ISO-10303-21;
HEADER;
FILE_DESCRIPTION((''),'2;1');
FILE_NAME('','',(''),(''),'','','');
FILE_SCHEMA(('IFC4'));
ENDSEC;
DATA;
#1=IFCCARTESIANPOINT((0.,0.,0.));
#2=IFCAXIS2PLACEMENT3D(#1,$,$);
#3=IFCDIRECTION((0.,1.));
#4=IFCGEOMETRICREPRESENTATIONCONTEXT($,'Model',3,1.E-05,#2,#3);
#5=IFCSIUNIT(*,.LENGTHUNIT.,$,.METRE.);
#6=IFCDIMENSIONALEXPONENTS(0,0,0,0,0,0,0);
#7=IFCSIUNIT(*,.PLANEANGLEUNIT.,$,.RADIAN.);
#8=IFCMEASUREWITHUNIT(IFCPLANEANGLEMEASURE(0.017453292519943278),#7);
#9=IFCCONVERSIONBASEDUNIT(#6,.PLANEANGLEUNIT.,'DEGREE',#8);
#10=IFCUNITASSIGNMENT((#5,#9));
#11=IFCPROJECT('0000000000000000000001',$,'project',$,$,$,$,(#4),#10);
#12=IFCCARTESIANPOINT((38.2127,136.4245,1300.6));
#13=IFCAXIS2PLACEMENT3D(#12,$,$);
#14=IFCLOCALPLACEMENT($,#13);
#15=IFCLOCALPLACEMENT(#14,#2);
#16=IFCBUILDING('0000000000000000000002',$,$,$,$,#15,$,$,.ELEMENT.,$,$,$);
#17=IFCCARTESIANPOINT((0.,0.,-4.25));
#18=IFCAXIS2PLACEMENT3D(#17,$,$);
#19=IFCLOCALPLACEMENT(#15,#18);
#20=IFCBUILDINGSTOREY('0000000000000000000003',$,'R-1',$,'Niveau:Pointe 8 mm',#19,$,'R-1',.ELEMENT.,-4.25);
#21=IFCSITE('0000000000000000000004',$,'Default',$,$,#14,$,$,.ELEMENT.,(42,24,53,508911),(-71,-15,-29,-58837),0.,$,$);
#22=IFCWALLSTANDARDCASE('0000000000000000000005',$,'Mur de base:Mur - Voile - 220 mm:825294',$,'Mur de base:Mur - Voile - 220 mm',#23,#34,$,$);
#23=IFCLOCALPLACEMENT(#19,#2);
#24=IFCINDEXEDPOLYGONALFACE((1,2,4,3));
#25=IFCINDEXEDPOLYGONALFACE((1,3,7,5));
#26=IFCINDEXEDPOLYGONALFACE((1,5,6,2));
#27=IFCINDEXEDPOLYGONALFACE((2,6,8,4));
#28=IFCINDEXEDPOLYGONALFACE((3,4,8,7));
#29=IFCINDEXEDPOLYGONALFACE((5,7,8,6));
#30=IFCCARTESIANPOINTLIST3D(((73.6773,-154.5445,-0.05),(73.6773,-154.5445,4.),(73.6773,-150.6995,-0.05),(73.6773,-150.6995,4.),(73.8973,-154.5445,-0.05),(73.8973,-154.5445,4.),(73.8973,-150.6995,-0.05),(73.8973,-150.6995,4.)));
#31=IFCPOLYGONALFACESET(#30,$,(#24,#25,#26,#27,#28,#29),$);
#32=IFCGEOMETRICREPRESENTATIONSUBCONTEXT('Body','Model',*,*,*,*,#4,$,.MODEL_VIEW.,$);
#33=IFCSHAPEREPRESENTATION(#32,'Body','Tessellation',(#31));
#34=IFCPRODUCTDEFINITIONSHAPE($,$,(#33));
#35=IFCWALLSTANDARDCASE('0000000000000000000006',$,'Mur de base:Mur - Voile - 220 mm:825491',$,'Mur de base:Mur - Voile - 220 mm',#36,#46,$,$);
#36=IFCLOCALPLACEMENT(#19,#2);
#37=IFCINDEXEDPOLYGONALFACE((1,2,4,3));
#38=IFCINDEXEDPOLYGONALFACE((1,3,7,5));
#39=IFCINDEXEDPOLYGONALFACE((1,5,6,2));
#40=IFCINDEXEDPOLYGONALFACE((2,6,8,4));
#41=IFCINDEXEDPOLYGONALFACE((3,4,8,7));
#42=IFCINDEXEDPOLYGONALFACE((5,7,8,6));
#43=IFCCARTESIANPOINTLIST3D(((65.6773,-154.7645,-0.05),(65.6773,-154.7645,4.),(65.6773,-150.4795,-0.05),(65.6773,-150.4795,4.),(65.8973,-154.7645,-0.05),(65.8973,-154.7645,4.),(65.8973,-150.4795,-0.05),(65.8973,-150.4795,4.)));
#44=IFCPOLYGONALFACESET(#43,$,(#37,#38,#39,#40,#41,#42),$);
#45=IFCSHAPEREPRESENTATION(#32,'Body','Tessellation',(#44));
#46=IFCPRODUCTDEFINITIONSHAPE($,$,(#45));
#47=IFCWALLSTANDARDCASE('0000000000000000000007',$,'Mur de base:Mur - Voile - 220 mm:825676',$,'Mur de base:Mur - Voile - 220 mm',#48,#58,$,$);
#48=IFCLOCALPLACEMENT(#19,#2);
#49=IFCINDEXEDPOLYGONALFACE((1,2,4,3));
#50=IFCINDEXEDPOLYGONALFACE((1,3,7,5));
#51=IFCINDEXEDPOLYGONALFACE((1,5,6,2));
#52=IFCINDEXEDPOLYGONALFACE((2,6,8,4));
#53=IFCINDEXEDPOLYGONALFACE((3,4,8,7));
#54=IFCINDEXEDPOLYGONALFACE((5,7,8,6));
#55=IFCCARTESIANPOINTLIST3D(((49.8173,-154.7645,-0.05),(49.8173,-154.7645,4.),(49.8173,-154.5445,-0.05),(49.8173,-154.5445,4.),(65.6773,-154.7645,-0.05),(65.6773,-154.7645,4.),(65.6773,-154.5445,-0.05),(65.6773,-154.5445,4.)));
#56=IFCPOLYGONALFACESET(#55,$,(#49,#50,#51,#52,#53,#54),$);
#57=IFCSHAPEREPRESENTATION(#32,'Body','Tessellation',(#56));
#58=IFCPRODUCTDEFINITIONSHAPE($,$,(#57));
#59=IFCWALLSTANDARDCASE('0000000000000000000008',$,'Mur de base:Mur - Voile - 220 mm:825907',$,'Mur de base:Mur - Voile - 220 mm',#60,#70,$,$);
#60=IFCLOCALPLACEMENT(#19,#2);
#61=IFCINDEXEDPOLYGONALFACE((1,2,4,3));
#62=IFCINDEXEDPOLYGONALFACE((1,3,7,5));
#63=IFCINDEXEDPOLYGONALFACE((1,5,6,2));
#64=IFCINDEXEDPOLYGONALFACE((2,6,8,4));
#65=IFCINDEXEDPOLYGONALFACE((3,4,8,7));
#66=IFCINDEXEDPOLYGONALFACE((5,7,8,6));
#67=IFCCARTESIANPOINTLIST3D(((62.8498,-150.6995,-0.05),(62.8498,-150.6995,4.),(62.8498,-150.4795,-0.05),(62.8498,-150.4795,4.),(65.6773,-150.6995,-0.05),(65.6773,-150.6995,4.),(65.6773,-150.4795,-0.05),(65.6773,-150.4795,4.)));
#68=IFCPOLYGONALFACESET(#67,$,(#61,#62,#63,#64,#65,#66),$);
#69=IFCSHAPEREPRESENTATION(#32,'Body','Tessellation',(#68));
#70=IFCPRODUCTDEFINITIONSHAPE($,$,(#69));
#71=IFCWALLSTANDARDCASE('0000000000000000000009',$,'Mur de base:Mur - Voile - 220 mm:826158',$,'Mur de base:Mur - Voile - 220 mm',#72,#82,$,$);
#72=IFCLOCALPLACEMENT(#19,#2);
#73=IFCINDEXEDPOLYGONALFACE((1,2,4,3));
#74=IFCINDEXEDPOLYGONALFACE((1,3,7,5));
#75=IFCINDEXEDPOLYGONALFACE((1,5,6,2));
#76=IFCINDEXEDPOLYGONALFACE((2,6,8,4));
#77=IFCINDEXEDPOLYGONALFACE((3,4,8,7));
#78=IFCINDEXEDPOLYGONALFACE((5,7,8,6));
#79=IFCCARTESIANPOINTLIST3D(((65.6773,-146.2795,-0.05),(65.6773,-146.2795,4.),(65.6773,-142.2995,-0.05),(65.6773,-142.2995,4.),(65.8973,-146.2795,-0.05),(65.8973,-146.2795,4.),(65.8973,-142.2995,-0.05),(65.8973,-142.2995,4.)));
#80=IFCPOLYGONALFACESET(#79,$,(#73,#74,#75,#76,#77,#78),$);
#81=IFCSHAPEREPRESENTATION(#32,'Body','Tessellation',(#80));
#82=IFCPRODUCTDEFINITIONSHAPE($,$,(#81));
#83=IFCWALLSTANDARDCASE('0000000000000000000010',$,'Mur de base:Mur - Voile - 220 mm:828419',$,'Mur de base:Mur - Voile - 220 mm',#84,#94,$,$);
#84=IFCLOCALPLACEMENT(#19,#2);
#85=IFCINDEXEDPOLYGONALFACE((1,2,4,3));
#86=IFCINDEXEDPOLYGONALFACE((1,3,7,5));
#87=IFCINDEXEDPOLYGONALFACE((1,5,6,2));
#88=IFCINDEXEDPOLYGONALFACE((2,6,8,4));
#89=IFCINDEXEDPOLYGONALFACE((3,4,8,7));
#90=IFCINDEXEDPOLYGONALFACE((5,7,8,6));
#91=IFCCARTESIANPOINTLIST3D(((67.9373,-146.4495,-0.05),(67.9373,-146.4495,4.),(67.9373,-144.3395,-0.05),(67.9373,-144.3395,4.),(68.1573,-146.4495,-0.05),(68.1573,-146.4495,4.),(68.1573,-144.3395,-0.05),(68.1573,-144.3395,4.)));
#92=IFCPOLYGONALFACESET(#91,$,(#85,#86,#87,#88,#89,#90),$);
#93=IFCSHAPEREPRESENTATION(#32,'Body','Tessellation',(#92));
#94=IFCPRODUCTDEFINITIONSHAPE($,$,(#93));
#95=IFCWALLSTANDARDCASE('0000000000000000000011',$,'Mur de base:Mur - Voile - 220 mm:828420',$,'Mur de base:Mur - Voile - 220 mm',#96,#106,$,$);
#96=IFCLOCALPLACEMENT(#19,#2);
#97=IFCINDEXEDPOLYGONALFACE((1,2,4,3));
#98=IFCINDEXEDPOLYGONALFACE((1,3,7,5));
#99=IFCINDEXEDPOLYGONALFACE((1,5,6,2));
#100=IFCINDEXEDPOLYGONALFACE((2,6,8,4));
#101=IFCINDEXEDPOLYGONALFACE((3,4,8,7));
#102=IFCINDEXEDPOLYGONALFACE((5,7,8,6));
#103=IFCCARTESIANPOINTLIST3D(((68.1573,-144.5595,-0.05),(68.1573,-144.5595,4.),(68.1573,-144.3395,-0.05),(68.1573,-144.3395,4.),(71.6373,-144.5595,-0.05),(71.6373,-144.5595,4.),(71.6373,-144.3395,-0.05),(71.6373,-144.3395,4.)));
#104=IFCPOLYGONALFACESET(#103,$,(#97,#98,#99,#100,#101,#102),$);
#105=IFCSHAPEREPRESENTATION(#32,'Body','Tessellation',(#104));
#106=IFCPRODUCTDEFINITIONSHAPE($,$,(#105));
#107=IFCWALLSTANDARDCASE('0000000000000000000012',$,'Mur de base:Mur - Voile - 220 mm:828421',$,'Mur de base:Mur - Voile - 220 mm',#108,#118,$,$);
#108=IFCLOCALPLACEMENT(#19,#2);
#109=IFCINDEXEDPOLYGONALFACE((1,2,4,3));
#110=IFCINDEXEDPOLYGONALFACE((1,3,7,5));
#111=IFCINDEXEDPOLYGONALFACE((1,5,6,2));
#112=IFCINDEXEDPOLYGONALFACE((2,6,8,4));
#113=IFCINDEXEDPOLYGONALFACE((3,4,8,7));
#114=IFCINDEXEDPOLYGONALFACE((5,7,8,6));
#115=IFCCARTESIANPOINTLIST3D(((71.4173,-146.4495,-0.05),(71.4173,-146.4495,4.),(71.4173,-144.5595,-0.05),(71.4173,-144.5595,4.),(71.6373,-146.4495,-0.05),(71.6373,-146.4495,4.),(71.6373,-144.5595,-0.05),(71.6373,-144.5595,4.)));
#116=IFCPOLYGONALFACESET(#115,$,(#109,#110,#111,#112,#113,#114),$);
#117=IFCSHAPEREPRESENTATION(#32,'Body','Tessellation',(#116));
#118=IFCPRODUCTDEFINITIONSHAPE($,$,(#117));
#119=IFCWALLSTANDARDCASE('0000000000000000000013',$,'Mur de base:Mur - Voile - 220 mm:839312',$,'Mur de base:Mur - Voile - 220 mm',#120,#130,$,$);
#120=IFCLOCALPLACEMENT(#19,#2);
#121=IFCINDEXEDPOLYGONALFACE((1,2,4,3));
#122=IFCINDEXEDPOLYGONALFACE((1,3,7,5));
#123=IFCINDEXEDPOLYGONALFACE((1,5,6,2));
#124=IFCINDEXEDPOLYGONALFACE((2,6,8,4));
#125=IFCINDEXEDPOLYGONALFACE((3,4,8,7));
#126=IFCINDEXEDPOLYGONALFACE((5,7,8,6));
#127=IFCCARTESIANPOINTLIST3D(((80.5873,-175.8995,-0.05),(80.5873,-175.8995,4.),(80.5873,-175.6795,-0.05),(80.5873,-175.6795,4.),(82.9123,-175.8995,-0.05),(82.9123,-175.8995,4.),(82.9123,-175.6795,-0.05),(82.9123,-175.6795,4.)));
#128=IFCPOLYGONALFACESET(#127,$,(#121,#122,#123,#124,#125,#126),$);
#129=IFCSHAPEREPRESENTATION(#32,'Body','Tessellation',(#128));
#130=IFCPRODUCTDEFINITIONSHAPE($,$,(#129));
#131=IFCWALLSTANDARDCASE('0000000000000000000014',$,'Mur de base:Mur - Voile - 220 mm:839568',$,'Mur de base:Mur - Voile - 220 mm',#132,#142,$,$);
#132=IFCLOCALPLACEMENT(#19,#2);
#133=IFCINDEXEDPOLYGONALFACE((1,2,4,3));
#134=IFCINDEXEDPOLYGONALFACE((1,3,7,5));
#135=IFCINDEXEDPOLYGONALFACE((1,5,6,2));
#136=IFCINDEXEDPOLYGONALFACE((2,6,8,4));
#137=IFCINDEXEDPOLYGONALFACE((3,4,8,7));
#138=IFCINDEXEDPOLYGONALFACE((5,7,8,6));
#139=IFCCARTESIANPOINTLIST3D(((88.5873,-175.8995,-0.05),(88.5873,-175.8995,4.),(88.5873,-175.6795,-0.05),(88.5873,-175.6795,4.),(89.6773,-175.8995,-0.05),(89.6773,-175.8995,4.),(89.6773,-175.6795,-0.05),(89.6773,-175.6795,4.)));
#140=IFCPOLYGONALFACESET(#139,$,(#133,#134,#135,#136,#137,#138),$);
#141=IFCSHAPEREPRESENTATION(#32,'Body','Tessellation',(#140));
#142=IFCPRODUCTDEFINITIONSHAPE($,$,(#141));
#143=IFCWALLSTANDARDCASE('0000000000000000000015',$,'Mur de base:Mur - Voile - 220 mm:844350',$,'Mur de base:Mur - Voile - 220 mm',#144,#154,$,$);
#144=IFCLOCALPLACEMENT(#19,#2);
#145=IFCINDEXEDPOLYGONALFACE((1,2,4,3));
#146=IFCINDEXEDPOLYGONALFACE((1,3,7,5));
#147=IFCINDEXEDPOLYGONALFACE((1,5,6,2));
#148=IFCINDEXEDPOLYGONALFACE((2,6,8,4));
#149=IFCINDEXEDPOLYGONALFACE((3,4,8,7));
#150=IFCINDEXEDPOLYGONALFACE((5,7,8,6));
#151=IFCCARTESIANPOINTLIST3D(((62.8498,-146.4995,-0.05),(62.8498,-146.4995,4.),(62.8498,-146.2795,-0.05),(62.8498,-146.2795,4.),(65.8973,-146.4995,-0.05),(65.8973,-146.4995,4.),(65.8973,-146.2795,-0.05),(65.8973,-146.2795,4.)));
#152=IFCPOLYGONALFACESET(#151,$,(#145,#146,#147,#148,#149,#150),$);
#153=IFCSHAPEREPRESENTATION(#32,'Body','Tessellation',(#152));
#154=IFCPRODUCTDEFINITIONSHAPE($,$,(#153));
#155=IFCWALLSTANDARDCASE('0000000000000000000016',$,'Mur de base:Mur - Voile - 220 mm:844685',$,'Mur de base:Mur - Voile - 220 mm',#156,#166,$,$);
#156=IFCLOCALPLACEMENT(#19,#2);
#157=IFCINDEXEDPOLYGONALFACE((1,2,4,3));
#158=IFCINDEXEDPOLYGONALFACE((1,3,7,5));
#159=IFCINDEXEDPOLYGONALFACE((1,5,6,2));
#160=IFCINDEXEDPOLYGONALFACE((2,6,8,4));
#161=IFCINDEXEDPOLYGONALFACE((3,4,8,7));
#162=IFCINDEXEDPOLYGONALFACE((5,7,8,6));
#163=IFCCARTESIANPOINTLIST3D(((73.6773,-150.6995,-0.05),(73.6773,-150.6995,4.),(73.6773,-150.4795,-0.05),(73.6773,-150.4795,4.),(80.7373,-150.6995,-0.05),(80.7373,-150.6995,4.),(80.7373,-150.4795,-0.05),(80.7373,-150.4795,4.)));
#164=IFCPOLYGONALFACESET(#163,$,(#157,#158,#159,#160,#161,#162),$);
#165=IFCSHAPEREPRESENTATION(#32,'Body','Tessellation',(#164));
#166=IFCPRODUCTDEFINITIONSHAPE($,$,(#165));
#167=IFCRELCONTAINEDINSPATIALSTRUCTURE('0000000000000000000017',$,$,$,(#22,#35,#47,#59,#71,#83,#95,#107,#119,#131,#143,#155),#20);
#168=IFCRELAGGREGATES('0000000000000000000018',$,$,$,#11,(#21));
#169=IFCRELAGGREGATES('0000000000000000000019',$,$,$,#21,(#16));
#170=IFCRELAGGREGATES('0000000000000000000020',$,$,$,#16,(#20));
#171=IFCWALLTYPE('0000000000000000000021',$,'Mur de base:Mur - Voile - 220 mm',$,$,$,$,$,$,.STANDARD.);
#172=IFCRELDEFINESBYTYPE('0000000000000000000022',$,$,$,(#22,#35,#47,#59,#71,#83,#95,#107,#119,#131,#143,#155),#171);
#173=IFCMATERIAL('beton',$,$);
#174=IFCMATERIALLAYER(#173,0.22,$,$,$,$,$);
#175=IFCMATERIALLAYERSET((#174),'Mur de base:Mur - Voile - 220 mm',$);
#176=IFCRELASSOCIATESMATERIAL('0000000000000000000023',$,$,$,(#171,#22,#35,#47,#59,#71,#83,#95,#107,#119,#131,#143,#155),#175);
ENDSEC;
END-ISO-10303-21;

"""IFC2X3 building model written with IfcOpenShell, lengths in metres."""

from ifc_helpers import new_model, entity, si_unit, converted_unit, direction, frame, frame_2d, origin, place, context, subcontext, project, spatial, polyline, rectangle, extrude, clip, bounded_halfspace, material, layer, layer_set, layer_usage, type_object, element, save


model = new_model("IFC2X3")

# Units and contexts
model_context = context("Model", 3, precision=1e-05, world=origin(), true_north=direction((0.0, 1.0)))
body_context = subcontext(model_context, "Body", "Model", "MODEL_VIEW")
ifc_project = project(units=[si_unit("LENGTHUNIT", "METRE"), converted_unit("PLANEANGLEUNIT", "DEGREE", entity("IfcPlaneAngleMeasure", 0.017453292519943278), si_unit("PLANEANGLEUNIT", "RADIAN"), dimensions=[0, 0, 0, 0, 0, 0, 0])], contexts=[model_context])

# Site, building, storey
site_placement = place(None, frame((38.2127, 136.4245, 1300.6)))
site = spatial("IfcSite", under=ifc_project, at=site_placement, Name="Default", CompositionType="ELEMENT", RefLatitude=(42, 24, 53, 508911), RefLongitude=(-71, -15, -29, -58837), RefElevation=0.0)
building_placement = place(site_placement, origin())
building = spatial("IfcBuilding", under=site, at=building_placement, CompositionType="ELEMENT")
storey_placement = place(building_placement, frame((0.0, 0.0, -4.25)))
storey = spatial("IfcBuildingStorey", under=building, at=storey_placement, Name="R-1", ObjectType="Niveau:Pointe 8 mm", LongName="R-1", CompositionType="ELEMENT", Elevation=-4.25)

# Walls
ifc_material_1 = material(Name="beton")
ifc_layer = layer(ifc_material_1, 0.22)
ifc_layer_set = layer_set([ifc_layer], Name="Mur de base:Mur - Voile - 220 mm")
wall_type = type_object("IfcWallType", Name="Mur de base:Mur - Voile - 220 mm", PredefinedType="STANDARD", material=ifc_layer_set)
ifc_layer_usage_1 = layer_usage(ifc_layer_set, "AXIS2", "NEGATIVE", 0.11)
wall_1_placement = place(storey_placement, frame((73.7873, -154.5445, -0.05), z_axis=(0.0, 0.0, 1.0), x_axis=(0.0, 1.0, 0.0)))
element("IfcWallStandardCase", 1, at=wall_1_placement, inside=storey, type_object=wall_type, material=ifc_layer_usage_1, Name="Mur de base:Mur - Voile - 220 mm:825294", ObjectType="Mur de base:Mur - Voile - 220 mm", context=body_context, shape_type="Clipping", body=[
    clip(extrude(rectangle(XDim=3.845, YDim=0.22, at=frame_2d((1.9225, 0.0), x_axis=(-1.0, 0.0))), origin(), (0.0, 0.0, 1.0), 4.05), bounded_halfspace(frame((0.0, -0.11, 4.05), z_axis=(0.0, 0.0, -1.0), x_axis=(-1.0, 0.0, 0.0)), True, frame((0.0, -0.11, 4.05)), polyline([(0.0, 0.0), (3.845, 0.0), (3.845, 0.22), (0.0, 0.22), (0.0, 0.0)]))),
])
ifc_layer_usage_2 = layer_usage(ifc_layer_set, "AXIS2", "NEGATIVE", 0.11)
wall_2_placement = place(storey_placement, frame((65.7873, -154.7645, -0.05), z_axis=(0.0, 0.0, 1.0), x_axis=(0.0, 1.0, 0.0)))
element("IfcWallStandardCase", 2, at=wall_2_placement, inside=storey, type_object=wall_type, material=ifc_layer_usage_2, Name="Mur de base:Mur - Voile - 220 mm:825491", ObjectType="Mur de base:Mur - Voile - 220 mm", context=body_context, shape_type="Clipping", body=[
    clip(extrude(rectangle(XDim=4.285, YDim=0.22, at=frame_2d((2.1425, 0.0), x_axis=(-1.0, 0.0))), origin(), (0.0, 0.0, 1.0), 4.05), bounded_halfspace(frame((0.0, -0.11, 4.05), z_axis=(0.0, 0.0, -1.0), x_axis=(-1.0, 0.0, 0.0)), True, frame((0.0, -0.11, 4.05)), polyline([(0.0, 0.0), (0.22, 0.0), (4.285, 0.0), (4.285, 0.22), (4.065, 0.22), (0.22, 0.22), (0.0, 0.22), (0.0, 0.0)]))),
])
ifc_layer_usage_3 = layer_usage(ifc_layer_set, "AXIS2", "NEGATIVE", 0.11)
wall_3_placement = place(storey_placement, frame((65.6773, -154.6545, -0.05), z_axis=(0.0, 0.0, 1.0), x_axis=(-1.0, 0.0, 0.0)))
element("IfcWallStandardCase", 3, at=wall_3_placement, inside=storey, type_object=wall_type, material=ifc_layer_usage_3, Name="Mur de base:Mur - Voile - 220 mm:825676", ObjectType="Mur de base:Mur - Voile - 220 mm", context=body_context, shape_type="Clipping", body=[
    clip(extrude(rectangle(XDim=15.86, YDim=0.22, at=frame_2d((7.93, 0.0), x_axis=(-1.0, 0.0))), origin(), (0.0, 0.0, 1.0), 4.05), bounded_halfspace(frame((0.0, -0.11, 4.05), z_axis=(0.0, 0.0, -1.0), x_axis=(0.0, 1.0, 0.0)), True, frame((0.0, -0.11, 4.05)), polyline([(0.0, 0.0), (15.44, 0.0), (15.79, 0.0), (15.86, 0.0), (15.86, 0.22), (15.79, 0.22), (15.44, 0.22), (0.0, 0.22), (0.0, 0.0)]))),
])
ifc_layer_usage_4 = layer_usage(ifc_layer_set, "AXIS2", "NEGATIVE", 0.11)
wall_4_placement = place(storey_placement, frame((65.6773, -150.5895, -0.05), z_axis=(0.0, 0.0, 1.0), x_axis=(-1.0, 0.0, 0.0)))
element("IfcWallStandardCase", 4, at=wall_4_placement, inside=storey, type_object=wall_type, material=ifc_layer_usage_4, Name="Mur de base:Mur - Voile - 220 mm:825907", ObjectType="Mur de base:Mur - Voile - 220 mm", context=body_context, shape_type="Clipping", body=[
    clip(extrude(rectangle(XDim=2.8275, YDim=0.22, at=frame_2d((1.4138, 0.0), x_axis=(-1.0, 0.0))), origin(), (0.0, 0.0, 1.0), 4.05), bounded_halfspace(frame((0.0, -0.11, 4.05), z_axis=(0.0, 0.0, -1.0), x_axis=(0.0, 1.0, 0.0)), True, frame((0.0, -0.11, 4.05)), polyline([(0.0, 0.0), (2.8275, 0.0), (2.8275, 0.22), (0.0, 0.22), (0.0, 0.0)]))),
])
ifc_layer_usage_5 = layer_usage(ifc_layer_set, "AXIS2", "NEGATIVE", 0.11)
wall_5_placement = place(storey_placement, frame((65.7873, -146.2795, -0.05), z_axis=(0.0, 0.0, 1.0), x_axis=(0.0, 1.0, 0.0)))
element("IfcWallStandardCase", 5, at=wall_5_placement, inside=storey, type_object=wall_type, material=ifc_layer_usage_5, Name="Mur de base:Mur - Voile - 220 mm:826158", ObjectType="Mur de base:Mur - Voile - 220 mm", context=body_context, shape_type="SweptSolid", body=[
    extrude(rectangle(XDim=3.98, YDim=0.22, at=frame_2d((1.99, 0.0), x_axis=(-1.0, 0.0))), origin(), (0.0, 0.0, 1.0), 4.05),
])
ifc_layer_usage_6 = layer_usage(ifc_layer_set, "AXIS2", "NEGATIVE", 0.11)
wall_6_placement = place(storey_placement, frame((68.0473, -146.4495, -0.05), z_axis=(0.0, 0.0, 1.0), x_axis=(0.0, 1.0, 0.0)))
element("IfcWallStandardCase", 6, at=wall_6_placement, inside=storey, type_object=wall_type, material=ifc_layer_usage_6, Name="Mur de base:Mur - Voile - 220 mm:828419", ObjectType="Mur de base:Mur - Voile - 220 mm", context=body_context, shape_type="SweptSolid", body=[
    extrude(rectangle(XDim=2.11, YDim=0.22, at=frame_2d((1.055, 0.0), x_axis=(-1.0, 0.0))), origin(), (0.0, 0.0, 1.0), 4.05),
])
ifc_layer_usage_7 = layer_usage(ifc_layer_set, "AXIS2", "NEGATIVE", 0.11)
wall_7_placement = place(storey_placement, frame((68.1573, -144.4495, -0.05)))
element("IfcWallStandardCase", 7, at=wall_7_placement, inside=storey, type_object=wall_type, material=ifc_layer_usage_7, Name="Mur de base:Mur - Voile - 220 mm:828420", ObjectType="Mur de base:Mur - Voile - 220 mm", context=body_context, shape_type="SweptSolid", body=[
    extrude(rectangle(XDim=3.48, YDim=0.22, at=frame_2d((1.74, 0.0), x_axis=(-1.0, 0.0))), origin(), (0.0, 0.0, 1.0), 4.05),
])
ifc_layer_usage_8 = layer_usage(ifc_layer_set, "AXIS2", "NEGATIVE", 0.11)
wall_8_placement = place(storey_placement, frame((71.5273, -144.5595, -0.05), z_axis=(0.0, 0.0, 1.0), x_axis=(0.0, -1.0, 0.0)))
element("IfcWallStandardCase", 8, at=wall_8_placement, inside=storey, type_object=wall_type, material=ifc_layer_usage_8, Name="Mur de base:Mur - Voile - 220 mm:828421", ObjectType="Mur de base:Mur - Voile - 220 mm", context=body_context, shape_type="SweptSolid", body=[
    extrude(rectangle(XDim=1.89, YDim=0.22, at=frame_2d((0.945, 0.0), x_axis=(-1.0, 0.0))), origin(), (0.0, 0.0, 1.0), 4.05),
])
ifc_layer_usage_9 = layer_usage(ifc_layer_set, "AXIS2", "NEGATIVE", 0.11)
wall_9_placement = place(storey_placement, frame((80.5873, -175.7895, -0.05)))
element("IfcWallStandardCase", 9, at=wall_9_placement, inside=storey, type_object=wall_type, material=ifc_layer_usage_9, Name="Mur de base:Mur - Voile - 220 mm:839312", ObjectType="Mur de base:Mur - Voile - 220 mm", context=body_context, shape_type="SweptSolid", body=[
    extrude(rectangle(XDim=2.325, YDim=0.22, at=frame_2d((1.1625, 0.0), x_axis=(-1.0, 0.0))), origin(), (0.0, 0.0, 1.0), 4.05),
])
ifc_layer_usage_10 = layer_usage(ifc_layer_set, "AXIS2", "NEGATIVE", 0.11)
wall_10_placement = place(storey_placement, frame((88.5873, -175.7895, -0.05)))
element("IfcWallStandardCase", 10, at=wall_10_placement, inside=storey, type_object=wall_type, material=ifc_layer_usage_10, Name="Mur de base:Mur - Voile - 220 mm:839568", ObjectType="Mur de base:Mur - Voile - 220 mm", context=body_context, shape_type="SweptSolid", body=[
    extrude(rectangle(XDim=1.09, YDim=0.22, at=frame_2d((0.545, 0.0), x_axis=(-1.0, 0.0))), origin(), (0.0, 0.0, 1.0), 4.05),
])
ifc_layer_usage_11 = layer_usage(ifc_layer_set, "AXIS2", "NEGATIVE", 0.11)
wall_11_placement = place(storey_placement, frame((62.8498, -146.3895, -0.05)))
element("IfcWallStandardCase", 11, at=wall_11_placement, inside=storey, type_object=wall_type, material=ifc_layer_usage_11, Name="Mur de base:Mur - Voile - 220 mm:844350", ObjectType="Mur de base:Mur - Voile - 220 mm", context=body_context, shape_type="Clipping", body=[
    clip(extrude(rectangle(XDim=3.0475, YDim=0.22, at=frame_2d((1.5238, 0.0), x_axis=(-1.0, 0.0))), origin(), (0.0, 0.0, 1.0), 4.05), bounded_halfspace(frame((0.0, -0.11, 4.05), z_axis=(0.0, 0.0, -1.0), x_axis=(0.0, -1.0, 0.0)), True, frame((0.0, -0.11, 4.05)), polyline([(0.0, 0.0), (2.8275, 0.0), (2.8275, 0.22), (0.0, 0.22), (0.0, 0.0)]))),
])
ifc_layer_usage_12 = layer_usage(ifc_layer_set, "AXIS2", "NEGATIVE", 0.11)
wall_12_placement = place(storey_placement, frame((80.7373, -150.5895, -0.05), z_axis=(0.0, 0.0, 1.0), x_axis=(-1.0, 0.0, 0.0)))
element("IfcWallStandardCase", 12, at=wall_12_placement, inside=storey, type_object=wall_type, material=ifc_layer_usage_12, Name="Mur de base:Mur - Voile - 220 mm:844685", ObjectType="Mur de base:Mur - Voile - 220 mm", context=body_context, shape_type="Clipping", body=[
    clip(extrude(rectangle(XDim=7.06, YDim=0.22, at=frame_2d((3.53, 0.0), x_axis=(-1.0, 0.0))), origin(), (0.0, 0.0, 1.0), 4.05), bounded_halfspace(frame((0.0, -0.11, 4.05), z_axis=(0.0, 0.0, -1.0), x_axis=(0.0, 1.0, 0.0)), True, frame((0.0, -0.11, 4.05)), polyline([(0.0, 0.0), (7.06, 0.0), (7.06, 0.22), (6.84, 0.22), (0.0, 0.22), (0.0, 0.0)]))),
])

save(model, "model.ifc")
